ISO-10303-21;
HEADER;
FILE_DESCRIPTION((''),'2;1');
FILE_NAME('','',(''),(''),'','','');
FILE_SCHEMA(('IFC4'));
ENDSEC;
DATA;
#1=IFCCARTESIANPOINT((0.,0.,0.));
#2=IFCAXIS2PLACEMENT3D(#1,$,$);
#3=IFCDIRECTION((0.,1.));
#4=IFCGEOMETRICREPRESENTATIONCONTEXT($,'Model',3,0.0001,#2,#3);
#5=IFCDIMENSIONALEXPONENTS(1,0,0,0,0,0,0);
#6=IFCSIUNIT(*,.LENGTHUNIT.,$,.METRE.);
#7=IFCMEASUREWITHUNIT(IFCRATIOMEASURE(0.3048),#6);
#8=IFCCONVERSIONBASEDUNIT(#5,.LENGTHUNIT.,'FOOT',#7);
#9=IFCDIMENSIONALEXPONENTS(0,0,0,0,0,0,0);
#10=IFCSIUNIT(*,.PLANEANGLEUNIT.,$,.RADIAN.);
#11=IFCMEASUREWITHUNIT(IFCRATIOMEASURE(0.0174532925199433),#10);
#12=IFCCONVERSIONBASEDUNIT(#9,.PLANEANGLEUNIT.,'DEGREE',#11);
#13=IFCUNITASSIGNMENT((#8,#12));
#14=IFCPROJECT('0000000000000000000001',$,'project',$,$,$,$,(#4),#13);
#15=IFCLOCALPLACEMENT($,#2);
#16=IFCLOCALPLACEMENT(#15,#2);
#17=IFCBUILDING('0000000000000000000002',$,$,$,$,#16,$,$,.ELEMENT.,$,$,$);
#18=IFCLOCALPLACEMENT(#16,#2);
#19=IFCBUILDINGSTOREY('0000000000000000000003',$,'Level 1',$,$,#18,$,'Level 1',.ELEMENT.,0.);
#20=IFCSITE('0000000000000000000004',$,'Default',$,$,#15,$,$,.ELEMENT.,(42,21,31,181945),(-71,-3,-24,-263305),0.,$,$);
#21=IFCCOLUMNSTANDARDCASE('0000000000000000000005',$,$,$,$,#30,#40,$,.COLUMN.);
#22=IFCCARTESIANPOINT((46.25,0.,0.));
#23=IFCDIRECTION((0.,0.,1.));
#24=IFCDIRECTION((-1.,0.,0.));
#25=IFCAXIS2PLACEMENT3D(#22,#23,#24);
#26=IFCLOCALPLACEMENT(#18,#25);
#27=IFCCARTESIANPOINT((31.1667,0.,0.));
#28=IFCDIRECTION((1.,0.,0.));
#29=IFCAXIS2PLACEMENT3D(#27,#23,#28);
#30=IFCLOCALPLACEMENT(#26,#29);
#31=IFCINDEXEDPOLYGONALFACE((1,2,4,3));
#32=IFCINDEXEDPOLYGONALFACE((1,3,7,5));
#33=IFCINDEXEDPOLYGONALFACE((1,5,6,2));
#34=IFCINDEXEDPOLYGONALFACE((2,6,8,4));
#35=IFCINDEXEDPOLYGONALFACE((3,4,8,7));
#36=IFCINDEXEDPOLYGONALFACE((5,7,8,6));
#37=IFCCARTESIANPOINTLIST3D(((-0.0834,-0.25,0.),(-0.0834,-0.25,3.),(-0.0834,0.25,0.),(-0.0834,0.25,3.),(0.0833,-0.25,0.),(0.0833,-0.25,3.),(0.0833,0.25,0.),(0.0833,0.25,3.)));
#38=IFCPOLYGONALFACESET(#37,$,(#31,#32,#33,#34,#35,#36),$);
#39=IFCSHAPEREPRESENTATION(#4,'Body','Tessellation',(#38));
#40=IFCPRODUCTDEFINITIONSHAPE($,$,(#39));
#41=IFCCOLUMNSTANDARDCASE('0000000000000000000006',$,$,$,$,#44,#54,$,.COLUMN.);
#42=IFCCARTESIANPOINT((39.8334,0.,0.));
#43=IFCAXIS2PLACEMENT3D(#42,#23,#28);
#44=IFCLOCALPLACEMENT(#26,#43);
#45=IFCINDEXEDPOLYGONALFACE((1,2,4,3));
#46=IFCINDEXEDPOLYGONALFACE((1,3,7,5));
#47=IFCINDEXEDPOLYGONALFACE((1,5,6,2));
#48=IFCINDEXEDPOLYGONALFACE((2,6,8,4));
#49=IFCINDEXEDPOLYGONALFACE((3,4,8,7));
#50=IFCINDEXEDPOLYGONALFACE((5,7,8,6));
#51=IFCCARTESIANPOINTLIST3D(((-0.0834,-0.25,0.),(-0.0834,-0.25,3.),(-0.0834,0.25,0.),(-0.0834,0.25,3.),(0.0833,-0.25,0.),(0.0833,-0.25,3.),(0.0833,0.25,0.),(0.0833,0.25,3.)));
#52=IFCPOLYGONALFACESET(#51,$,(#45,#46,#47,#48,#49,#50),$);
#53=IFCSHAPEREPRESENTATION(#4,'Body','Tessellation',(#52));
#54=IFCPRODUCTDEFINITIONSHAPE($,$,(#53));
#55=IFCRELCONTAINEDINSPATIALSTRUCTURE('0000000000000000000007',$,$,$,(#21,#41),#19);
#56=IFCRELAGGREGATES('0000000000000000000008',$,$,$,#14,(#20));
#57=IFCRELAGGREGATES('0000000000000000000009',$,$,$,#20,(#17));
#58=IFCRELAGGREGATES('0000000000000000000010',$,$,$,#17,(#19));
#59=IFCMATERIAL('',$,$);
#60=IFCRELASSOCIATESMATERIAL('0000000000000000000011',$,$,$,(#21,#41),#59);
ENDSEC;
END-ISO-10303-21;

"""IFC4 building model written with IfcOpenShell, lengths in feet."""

from ifc_helpers import new_model, entity, si_unit, converted_unit, direction, frame, origin, place, context, project, spatial, rectangle, extrude, material, element, save


model = new_model("IFC4")

# Units and contexts
model_context = context("Model", 3, precision=0.0001, world=origin(), true_north=direction((0.0, 1.0)))
ifc_project = project(units=[converted_unit("LENGTHUNIT", "FOOT", entity("IfcRatioMeasure", 0.3048), si_unit("LENGTHUNIT", "METRE"), dimensions=[1, 0, 0, 0, 0, 0, 0]), converted_unit("PLANEANGLEUNIT", "DEGREE", entity("IfcRatioMeasure", 0.0174532925199433), si_unit("PLANEANGLEUNIT", "RADIAN"), dimensions=[0, 0, 0, 0, 0, 0, 0])], contexts=[model_context])

# Site, building, storey
site_placement = place(None, origin())
site = spatial("IfcSite", under=ifc_project, at=site_placement, Name="Default", CompositionType="ELEMENT", RefLatitude=(42, 21, 31, 181945), RefLongitude=(-71, -3, -24, -263305), RefElevation=0.0)
building_placement = place(site_placement, origin())
building = spatial("IfcBuilding", under=site, at=building_placement, CompositionType="ELEMENT")
storey_placement = place(building_placement, origin())
storey = spatial("IfcBuildingStorey", under=building, at=storey_placement, Name="Level 1", LongName="Level 1", CompositionType="ELEMENT", Elevation=0.0)

# Columns
placement_1 = place(storey_placement, frame((46.25, 0.0, 0.0), z_axis=(0.0, 0.0, 1.0), x_axis=(-1.0, 0.0, 0.0)))
ifc_material_1 = material(Name="")
for number, where, z_axis, x_axis in (
    (1, (31.1667, 0.0, 0.0), (0.0, 0.0, 1.0), (1.0, 0.0, 0.0)),
    (2, (39.8334, 0.0, 0.0), (0.0, 0.0, 1.0), (1.0, 0.0, 0.0)),
):
    element("IfcColumnStandardCase", number, at=place(placement_1, frame(where, z_axis=z_axis, x_axis=x_axis)), inside=storey, material=ifc_material_1, PredefinedType="COLUMN", context=model_context, shape_type="SweptSolid", body=[
        extrude(rectangle(XDim=0.1667, YDim=0.5), origin(), (0.0, 0.0, 1.0), 3.0),
    ])

save(model, "model.ifc")
